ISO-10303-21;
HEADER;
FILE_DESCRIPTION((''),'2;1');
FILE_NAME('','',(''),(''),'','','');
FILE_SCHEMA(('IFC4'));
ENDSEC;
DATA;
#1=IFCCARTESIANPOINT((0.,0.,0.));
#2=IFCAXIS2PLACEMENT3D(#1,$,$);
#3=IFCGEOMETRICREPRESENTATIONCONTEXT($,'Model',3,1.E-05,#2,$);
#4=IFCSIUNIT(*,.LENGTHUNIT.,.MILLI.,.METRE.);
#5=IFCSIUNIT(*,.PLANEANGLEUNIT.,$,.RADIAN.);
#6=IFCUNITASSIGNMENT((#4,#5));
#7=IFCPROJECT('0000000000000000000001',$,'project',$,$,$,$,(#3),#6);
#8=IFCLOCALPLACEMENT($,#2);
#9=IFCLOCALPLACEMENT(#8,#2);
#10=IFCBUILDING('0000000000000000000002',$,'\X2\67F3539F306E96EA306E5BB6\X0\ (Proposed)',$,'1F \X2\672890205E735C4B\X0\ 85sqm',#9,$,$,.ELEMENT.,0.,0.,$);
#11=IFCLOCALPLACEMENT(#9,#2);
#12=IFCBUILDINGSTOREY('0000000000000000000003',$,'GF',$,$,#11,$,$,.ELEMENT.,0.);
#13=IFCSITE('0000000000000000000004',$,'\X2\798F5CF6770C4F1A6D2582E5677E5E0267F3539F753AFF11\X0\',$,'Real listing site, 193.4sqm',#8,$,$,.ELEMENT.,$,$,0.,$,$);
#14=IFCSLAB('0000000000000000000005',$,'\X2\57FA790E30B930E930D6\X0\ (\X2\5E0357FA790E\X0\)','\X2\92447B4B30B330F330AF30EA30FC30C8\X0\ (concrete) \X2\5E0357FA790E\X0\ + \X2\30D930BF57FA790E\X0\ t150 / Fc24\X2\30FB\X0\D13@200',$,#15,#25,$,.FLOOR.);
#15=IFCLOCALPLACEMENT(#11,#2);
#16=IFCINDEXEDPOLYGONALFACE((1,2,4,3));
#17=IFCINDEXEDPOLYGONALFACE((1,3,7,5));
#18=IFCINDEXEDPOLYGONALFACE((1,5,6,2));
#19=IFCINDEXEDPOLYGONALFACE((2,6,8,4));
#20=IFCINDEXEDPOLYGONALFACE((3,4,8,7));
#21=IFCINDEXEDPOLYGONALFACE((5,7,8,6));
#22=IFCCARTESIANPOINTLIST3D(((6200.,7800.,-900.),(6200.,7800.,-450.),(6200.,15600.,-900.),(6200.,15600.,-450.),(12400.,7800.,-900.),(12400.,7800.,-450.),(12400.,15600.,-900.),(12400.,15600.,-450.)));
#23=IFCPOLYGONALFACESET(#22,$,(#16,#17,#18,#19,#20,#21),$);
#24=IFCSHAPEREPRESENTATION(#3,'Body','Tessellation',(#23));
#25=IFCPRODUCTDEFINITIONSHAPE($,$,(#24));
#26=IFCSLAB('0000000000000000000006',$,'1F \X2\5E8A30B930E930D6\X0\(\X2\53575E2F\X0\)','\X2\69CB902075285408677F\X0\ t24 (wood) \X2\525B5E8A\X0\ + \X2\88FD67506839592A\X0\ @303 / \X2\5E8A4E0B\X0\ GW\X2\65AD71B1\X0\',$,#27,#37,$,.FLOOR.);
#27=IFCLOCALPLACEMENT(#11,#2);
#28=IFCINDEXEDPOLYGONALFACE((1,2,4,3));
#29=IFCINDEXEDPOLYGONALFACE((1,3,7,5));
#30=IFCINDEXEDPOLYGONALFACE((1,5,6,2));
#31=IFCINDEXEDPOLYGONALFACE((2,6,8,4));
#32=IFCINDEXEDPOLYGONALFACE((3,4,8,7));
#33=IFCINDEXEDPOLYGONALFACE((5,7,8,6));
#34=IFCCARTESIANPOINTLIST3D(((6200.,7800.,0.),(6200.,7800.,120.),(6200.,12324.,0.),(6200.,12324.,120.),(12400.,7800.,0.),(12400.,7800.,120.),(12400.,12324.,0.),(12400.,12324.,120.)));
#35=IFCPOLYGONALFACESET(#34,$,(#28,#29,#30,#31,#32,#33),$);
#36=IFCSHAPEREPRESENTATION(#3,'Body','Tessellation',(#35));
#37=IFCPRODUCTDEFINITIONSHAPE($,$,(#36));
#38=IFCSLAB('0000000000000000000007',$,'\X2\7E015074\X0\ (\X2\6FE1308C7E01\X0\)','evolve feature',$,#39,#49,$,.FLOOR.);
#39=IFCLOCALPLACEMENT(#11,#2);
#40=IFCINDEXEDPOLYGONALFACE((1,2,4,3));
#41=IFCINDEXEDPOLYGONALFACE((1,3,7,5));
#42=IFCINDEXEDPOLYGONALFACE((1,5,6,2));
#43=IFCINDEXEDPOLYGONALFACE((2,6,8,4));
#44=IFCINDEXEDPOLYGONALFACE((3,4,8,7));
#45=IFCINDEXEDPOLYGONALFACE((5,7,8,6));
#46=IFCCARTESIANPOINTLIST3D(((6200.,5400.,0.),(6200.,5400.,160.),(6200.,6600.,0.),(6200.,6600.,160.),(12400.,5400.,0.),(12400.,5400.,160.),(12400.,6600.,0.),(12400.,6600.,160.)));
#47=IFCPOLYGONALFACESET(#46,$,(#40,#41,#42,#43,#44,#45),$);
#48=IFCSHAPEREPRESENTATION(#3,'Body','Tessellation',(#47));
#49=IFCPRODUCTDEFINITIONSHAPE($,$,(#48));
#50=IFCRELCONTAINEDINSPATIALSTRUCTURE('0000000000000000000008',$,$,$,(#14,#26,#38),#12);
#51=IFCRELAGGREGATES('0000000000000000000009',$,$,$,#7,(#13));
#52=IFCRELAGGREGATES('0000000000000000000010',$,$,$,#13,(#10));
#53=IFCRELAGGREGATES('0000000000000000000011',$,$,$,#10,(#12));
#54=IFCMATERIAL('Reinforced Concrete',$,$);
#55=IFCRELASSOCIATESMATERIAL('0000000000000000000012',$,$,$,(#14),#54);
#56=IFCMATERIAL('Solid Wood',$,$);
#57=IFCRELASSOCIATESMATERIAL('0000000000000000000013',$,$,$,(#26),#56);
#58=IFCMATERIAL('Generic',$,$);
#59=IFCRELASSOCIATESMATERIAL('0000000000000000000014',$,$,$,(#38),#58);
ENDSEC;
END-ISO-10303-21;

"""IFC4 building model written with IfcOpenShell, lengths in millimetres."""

from ifc_helpers import new_model, si_unit, frame, frame_2d, origin, place, context, project, spatial, rectangle, extrude, material, element, save


model = new_model("IFC4")

# Units and contexts
model_context = context("Model", 3, precision=1e-05, world=origin())
ifc_project = project(units=[si_unit("LENGTHUNIT", "METRE", prefix="MILLI"), si_unit("PLANEANGLEUNIT", "RADIAN")], contexts=[model_context])

# Site, building, storey
site_placement = place(None, origin())
site = spatial("IfcSite", under=ifc_project, at=site_placement, Name="福島県会津若松市柳原町１", ObjectType="Real listing site, 193.4sqm", CompositionType="ELEMENT", RefElevation=0.0)
building_placement = place(site_placement, origin())
building = spatial("IfcBuilding", under=site, at=building_placement, Name="柳原の雪の家 (Proposed)", ObjectType="1F 木造平屋 85sqm", CompositionType="ELEMENT", ElevationOfRefHeight=0.0, ElevationOfTerrain=0.0)
storey_placement = place(building_placement, origin())
storey = spatial("IfcBuildingStorey", under=building, at=storey_placement, Name="GF", CompositionType="ELEMENT", Elevation=0.0)

# Slabs
ifc_material_1 = material(Name="Reinforced Concrete")
slab_1_placement = place(storey_placement, frame((3100.0, 3900.0, -450.0)))
element("IfcSlab", 1, at=slab_1_placement, inside=storey, material=ifc_material_1, Name="基礎スラブ (布基礎)", Description="鉄筋コンクリート (concrete) 布基礎 + ベタ基礎 t150 / Fc24・D13@200", PredefinedType="FLOOR", context=model_context, shape_type="SweptSolid", body=[
    extrude(rectangle(XDim=6200.0, YDim=7800.0, at=frame_2d((3100.0, 3900.0))), frame((3100.0, 3900.0, -450.0)), (0.0, 0.0, 1.0), 450.0),
])
ifc_material_2 = material(Name="Solid Wood")
slab_2_placement = place(storey_placement, frame((3100.0, 3900.0, 0.0)))
element("IfcSlab", 2, at=slab_2_placement, inside=storey, material=ifc_material_2, Name="1F 床スラブ(南帯)", Description="構造用合板 t24 (wood) 剛床 + 製材根太 @303 / 床下 GW断熱", PredefinedType="FLOOR", context=model_context, shape_type="SweptSolid", body=[
    extrude(rectangle(XDim=6200.0, YDim=4524.0, at=frame_2d((3100.0, 2262.0))), frame((3100.0, 3900.0, 0.0)), (0.0, 0.0, 1.0), 120.0),
])
ifc_material_3 = material(Name="Generic")
slab_3_placement = place(storey_placement, frame((3100.0, 2700.0, 0.0)))
element("IfcSlab", 3, at=slab_3_placement, inside=storey, material=ifc_material_3, Name="縁側 (濡れ縁)", Description="evolve feature", PredefinedType="FLOOR", context=model_context, shape_type="SweptSolid", body=[
    extrude(rectangle(XDim=6200.0, YDim=1200.0, at=frame_2d((3100.0, 600.0))), frame((3100.0, 2700.0, 0.0)), (0.0, 0.0, 1.0), 160.0),
])

save(model, "model.ifc")
